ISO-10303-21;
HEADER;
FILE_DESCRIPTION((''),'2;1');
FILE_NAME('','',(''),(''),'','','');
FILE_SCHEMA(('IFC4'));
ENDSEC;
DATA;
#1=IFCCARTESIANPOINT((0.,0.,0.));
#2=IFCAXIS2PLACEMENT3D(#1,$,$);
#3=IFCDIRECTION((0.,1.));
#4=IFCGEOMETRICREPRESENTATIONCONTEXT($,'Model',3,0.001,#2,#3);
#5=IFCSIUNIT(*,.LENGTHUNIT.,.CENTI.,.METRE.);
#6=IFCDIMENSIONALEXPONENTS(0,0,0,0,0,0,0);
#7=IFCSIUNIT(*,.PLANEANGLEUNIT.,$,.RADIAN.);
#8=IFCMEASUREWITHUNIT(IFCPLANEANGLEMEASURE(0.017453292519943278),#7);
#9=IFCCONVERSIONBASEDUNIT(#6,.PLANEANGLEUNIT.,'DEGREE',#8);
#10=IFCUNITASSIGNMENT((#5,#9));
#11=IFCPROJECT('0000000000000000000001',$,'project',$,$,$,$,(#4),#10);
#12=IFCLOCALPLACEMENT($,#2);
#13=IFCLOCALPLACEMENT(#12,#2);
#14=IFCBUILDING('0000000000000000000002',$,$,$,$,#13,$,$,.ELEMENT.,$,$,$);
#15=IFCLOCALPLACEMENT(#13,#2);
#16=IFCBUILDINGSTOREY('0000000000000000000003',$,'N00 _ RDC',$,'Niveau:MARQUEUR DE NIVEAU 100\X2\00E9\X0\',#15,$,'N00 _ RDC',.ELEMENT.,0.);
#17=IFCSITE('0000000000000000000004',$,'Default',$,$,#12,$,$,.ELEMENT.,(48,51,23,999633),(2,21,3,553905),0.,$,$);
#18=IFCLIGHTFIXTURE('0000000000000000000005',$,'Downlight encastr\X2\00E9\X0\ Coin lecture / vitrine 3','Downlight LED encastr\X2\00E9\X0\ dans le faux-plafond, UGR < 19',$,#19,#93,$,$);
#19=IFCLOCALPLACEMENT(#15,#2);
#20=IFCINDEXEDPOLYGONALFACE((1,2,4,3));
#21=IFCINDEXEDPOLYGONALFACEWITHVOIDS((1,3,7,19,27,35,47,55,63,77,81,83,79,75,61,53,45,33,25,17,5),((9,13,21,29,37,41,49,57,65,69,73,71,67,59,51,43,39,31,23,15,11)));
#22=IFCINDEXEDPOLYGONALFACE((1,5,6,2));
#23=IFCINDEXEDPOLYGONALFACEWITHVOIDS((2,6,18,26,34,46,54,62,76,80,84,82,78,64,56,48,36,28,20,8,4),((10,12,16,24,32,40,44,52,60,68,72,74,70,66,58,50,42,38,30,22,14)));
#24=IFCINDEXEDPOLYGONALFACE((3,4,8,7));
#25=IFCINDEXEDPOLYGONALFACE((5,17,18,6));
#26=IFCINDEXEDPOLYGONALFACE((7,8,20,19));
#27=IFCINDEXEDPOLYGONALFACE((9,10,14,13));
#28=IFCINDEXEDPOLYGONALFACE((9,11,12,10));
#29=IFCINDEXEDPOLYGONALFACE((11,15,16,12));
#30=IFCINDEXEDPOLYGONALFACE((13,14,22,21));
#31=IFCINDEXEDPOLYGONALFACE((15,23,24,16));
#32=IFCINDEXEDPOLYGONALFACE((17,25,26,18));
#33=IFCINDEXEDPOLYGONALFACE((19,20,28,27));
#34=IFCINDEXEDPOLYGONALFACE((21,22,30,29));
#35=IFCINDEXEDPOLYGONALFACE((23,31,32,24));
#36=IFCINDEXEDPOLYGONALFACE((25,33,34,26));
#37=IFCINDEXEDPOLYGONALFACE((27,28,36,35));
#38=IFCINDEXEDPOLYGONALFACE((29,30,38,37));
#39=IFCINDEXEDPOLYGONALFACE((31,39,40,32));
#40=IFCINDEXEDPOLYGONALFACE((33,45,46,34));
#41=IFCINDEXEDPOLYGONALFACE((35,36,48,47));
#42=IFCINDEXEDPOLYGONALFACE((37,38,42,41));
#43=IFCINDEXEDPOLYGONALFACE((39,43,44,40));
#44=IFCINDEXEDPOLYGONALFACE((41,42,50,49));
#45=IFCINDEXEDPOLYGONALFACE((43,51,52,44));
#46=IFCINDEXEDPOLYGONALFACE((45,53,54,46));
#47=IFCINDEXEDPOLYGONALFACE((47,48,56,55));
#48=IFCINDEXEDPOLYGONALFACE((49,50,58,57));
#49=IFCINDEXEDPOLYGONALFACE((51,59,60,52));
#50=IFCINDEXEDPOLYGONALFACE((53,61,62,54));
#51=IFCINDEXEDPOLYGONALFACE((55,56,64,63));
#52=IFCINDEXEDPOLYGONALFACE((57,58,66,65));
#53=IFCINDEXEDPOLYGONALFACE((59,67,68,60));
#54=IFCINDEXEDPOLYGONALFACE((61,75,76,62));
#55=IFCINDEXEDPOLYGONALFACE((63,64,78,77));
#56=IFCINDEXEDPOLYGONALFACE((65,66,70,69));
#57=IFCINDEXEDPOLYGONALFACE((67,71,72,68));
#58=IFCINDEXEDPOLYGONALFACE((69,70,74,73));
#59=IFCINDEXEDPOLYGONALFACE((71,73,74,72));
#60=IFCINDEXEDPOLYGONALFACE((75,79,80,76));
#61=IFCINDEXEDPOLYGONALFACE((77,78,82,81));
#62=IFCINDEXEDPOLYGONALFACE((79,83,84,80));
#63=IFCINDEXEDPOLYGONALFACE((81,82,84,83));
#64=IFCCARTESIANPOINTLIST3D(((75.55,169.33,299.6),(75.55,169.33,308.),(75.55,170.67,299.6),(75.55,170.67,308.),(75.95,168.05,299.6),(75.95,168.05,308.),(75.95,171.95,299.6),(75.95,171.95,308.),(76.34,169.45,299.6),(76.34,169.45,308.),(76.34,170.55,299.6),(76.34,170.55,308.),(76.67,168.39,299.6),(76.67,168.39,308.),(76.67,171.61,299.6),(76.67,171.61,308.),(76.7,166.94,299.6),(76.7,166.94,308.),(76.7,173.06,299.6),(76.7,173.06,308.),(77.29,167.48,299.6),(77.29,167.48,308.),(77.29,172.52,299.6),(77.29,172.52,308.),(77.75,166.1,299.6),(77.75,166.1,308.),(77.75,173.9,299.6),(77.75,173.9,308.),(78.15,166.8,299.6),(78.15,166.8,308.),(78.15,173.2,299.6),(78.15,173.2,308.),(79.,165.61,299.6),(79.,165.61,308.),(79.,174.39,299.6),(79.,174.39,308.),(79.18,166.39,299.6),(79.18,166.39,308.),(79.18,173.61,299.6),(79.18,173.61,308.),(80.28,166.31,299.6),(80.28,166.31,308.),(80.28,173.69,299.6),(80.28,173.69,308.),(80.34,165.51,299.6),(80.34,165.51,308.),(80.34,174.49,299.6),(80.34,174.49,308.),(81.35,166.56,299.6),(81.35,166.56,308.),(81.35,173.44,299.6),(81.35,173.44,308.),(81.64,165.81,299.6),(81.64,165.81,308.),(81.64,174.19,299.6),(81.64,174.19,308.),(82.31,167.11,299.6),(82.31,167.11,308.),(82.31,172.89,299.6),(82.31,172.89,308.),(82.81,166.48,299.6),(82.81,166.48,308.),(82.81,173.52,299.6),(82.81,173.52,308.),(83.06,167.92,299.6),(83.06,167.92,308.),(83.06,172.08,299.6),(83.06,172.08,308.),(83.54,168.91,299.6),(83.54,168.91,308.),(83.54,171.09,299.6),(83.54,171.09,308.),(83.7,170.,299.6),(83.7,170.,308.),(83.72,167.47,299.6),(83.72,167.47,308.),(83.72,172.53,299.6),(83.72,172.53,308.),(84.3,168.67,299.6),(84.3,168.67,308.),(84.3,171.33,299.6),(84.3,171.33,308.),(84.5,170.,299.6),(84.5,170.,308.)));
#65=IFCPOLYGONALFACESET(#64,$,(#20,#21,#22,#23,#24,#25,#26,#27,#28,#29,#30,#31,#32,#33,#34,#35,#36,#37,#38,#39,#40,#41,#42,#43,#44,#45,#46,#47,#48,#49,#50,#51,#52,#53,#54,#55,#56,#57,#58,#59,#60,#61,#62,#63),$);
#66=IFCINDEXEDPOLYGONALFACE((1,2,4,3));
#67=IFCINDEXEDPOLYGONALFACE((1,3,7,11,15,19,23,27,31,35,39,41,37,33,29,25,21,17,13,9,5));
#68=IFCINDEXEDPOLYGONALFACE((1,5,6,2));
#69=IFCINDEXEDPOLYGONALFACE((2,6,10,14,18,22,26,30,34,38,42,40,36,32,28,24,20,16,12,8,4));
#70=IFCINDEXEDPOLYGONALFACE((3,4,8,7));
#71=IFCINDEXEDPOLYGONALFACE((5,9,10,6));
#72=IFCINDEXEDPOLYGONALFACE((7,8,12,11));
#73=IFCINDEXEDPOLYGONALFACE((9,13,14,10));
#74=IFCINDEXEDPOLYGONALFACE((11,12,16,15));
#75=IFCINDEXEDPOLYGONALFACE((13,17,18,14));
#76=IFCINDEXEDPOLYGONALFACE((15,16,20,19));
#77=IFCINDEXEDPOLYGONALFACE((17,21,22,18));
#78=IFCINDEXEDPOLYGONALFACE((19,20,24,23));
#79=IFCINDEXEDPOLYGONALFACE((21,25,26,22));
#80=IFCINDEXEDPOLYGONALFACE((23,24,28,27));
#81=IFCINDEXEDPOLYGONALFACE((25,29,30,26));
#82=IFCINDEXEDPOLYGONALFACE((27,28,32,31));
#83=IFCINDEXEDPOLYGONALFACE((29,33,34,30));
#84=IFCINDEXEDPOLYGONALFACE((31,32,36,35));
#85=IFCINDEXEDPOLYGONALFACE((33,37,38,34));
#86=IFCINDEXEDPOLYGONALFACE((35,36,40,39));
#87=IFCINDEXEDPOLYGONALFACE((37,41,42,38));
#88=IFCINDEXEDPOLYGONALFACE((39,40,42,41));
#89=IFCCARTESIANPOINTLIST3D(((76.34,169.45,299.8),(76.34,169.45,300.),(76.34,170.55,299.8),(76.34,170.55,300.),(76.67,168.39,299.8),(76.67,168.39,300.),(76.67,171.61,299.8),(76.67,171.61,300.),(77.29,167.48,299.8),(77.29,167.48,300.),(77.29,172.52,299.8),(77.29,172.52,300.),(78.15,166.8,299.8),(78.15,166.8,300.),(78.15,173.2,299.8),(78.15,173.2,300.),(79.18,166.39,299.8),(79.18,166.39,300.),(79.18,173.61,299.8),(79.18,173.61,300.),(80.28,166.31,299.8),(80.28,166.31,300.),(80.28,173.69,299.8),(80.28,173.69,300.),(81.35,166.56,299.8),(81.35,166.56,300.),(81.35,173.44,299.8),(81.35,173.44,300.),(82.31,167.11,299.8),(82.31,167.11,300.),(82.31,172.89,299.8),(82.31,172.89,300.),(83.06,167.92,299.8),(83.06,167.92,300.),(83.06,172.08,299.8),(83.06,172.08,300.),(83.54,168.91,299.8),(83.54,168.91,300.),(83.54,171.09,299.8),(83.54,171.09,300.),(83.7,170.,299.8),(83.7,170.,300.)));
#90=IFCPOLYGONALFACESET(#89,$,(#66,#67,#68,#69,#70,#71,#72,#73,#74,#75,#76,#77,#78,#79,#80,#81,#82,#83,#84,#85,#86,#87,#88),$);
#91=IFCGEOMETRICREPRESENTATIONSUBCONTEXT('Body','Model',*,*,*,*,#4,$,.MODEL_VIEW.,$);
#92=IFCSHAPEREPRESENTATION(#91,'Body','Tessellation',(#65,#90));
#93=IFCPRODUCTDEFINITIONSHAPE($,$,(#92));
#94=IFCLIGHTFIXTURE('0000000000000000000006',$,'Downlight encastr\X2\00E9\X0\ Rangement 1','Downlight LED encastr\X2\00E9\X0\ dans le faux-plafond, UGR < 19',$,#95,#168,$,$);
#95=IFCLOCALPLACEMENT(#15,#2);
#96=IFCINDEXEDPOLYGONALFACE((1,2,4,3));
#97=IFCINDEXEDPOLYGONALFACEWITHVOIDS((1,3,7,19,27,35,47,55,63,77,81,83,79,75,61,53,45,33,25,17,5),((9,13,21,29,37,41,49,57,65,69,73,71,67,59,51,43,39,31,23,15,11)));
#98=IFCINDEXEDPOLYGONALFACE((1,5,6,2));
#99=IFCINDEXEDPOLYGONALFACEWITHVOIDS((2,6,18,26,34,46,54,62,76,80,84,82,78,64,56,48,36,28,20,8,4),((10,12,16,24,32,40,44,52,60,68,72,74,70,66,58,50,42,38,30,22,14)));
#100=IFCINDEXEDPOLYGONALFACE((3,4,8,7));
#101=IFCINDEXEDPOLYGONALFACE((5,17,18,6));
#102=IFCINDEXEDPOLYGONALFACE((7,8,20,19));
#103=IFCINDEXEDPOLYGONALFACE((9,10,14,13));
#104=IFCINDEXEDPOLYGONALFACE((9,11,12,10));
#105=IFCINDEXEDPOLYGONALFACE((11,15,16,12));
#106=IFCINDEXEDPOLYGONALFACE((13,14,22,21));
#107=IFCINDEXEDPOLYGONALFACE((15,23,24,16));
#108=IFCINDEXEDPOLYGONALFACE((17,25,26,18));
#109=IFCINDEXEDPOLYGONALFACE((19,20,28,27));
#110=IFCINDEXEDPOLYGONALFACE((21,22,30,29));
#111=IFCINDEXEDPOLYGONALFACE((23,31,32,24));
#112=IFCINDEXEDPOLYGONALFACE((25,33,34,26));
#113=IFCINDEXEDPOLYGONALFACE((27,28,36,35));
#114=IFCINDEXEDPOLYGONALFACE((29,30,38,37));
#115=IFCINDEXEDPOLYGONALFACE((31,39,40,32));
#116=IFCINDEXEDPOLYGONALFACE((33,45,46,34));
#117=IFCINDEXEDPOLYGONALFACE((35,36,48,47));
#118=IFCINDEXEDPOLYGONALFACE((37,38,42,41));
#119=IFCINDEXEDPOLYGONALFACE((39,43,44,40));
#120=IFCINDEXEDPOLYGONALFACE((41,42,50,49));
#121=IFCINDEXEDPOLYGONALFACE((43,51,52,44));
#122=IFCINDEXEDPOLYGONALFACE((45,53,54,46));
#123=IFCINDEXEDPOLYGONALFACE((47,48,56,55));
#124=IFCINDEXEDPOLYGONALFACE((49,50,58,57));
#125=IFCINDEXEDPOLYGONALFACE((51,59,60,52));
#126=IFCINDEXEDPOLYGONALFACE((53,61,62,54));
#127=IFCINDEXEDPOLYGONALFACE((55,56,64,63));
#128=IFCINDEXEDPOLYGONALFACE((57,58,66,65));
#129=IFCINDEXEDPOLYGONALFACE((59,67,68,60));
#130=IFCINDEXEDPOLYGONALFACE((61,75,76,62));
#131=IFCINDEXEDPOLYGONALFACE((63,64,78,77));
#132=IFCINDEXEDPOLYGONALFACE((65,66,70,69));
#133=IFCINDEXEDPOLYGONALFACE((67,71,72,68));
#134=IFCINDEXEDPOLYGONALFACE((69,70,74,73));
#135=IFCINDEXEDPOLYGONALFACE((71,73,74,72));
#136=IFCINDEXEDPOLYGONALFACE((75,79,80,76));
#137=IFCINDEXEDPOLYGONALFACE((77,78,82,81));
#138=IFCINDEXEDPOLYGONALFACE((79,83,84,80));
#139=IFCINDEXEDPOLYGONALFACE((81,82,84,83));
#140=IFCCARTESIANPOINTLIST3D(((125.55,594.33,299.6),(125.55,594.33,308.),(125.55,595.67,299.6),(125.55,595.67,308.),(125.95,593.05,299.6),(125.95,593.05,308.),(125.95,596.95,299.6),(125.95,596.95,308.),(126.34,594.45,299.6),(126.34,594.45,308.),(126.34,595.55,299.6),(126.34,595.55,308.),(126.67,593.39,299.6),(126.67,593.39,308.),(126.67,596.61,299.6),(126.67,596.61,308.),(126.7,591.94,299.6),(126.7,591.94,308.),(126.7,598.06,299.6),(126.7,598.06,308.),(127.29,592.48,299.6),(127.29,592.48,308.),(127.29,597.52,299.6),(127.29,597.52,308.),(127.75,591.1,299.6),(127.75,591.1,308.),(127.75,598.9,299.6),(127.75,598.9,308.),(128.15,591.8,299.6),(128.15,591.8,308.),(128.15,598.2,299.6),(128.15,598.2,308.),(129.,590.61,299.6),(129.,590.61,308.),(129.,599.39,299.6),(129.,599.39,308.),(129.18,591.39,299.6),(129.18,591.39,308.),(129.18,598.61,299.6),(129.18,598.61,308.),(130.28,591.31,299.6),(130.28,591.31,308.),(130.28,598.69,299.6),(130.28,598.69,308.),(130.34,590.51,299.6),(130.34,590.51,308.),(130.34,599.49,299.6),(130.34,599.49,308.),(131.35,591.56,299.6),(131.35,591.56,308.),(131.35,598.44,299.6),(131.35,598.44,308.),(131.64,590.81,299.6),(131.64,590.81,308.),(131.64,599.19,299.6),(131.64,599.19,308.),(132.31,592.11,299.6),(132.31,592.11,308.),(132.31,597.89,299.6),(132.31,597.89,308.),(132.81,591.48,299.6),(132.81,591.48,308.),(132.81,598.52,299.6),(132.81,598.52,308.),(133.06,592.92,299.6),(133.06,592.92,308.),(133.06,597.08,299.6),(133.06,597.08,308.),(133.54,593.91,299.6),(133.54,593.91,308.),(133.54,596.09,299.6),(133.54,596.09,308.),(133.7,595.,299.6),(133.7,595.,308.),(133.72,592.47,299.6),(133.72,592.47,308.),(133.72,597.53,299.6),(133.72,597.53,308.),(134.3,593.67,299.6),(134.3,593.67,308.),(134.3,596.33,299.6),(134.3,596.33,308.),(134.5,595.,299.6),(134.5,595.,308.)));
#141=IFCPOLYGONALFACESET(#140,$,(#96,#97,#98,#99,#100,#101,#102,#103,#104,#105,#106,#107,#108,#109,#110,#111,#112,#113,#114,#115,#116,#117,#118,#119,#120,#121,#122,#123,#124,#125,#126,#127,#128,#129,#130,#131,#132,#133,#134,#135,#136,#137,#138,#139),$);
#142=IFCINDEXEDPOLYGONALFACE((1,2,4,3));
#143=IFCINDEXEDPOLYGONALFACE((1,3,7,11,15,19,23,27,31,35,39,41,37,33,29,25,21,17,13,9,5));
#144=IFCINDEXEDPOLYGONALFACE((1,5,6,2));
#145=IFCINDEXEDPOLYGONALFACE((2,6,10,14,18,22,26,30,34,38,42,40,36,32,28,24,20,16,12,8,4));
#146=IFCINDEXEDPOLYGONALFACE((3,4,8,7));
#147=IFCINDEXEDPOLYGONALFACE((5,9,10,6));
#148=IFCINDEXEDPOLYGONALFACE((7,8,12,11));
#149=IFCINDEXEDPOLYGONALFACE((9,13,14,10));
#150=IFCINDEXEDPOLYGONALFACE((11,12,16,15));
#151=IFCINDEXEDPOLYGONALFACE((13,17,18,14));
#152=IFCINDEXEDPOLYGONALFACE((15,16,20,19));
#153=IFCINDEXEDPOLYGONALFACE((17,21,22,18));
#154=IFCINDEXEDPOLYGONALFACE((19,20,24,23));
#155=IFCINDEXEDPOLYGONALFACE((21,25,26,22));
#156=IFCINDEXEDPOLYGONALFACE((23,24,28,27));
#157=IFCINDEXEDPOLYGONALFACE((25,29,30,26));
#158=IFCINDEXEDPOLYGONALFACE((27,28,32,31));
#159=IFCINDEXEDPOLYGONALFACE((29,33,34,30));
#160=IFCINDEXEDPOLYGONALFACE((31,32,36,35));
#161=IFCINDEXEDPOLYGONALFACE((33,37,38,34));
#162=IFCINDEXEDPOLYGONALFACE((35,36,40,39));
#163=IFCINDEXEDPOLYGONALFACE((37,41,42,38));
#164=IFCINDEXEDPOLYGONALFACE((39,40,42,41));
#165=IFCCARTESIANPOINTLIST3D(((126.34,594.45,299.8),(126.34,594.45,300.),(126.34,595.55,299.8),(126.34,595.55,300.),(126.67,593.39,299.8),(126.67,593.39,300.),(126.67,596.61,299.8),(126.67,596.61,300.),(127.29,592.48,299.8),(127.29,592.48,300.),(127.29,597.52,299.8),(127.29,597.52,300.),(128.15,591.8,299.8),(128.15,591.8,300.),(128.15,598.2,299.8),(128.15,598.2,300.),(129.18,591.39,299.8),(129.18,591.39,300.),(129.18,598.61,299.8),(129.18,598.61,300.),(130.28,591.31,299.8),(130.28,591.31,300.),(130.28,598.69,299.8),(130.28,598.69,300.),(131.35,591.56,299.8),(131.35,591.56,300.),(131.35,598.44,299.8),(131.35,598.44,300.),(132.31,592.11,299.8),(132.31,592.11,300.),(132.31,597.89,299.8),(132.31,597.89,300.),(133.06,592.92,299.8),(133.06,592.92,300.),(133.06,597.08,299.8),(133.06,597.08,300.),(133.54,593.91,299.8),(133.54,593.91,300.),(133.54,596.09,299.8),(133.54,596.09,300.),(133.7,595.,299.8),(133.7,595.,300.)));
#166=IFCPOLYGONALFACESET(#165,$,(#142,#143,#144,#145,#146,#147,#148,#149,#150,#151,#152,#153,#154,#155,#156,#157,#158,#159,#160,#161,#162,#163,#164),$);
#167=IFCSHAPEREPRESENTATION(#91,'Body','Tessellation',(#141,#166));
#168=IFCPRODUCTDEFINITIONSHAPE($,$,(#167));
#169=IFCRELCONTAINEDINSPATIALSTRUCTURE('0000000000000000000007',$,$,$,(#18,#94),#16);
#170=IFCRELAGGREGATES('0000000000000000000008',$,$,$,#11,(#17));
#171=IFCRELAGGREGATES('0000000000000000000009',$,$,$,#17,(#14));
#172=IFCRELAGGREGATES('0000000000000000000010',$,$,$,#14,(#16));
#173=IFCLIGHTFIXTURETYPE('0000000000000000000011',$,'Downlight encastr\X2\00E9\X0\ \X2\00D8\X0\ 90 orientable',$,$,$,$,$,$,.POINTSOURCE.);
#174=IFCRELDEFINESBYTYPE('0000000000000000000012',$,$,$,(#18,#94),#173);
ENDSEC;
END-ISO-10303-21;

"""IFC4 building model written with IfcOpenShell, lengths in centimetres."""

from ifc_helpers import new_model, entity, si_unit, converted_unit, direction, frame, frame_2d, origin, origin_with_axes, place, context, subcontext, project, spatial, circle, hollow_circle, extrude, type_object, element, save


model = new_model("IFC4")

# Units and contexts
model_context = context("Model", 3, precision=0.001, world=origin(), true_north=direction((0.0, 1.0)))
body_context = subcontext(model_context, "Body", "Model", "MODEL_VIEW")
ifc_project = project(units=[si_unit("LENGTHUNIT", "METRE", prefix="CENTI"), converted_unit("PLANEANGLEUNIT", "DEGREE", entity("IfcPlaneAngleMeasure", 0.017453292519943278), si_unit("PLANEANGLEUNIT", "RADIAN"), dimensions=[0, 0, 0, 0, 0, 0, 0])], contexts=[model_context])

# Site, building, storey
site_placement = place(None, origin())
site = spatial("IfcSite", under=ifc_project, at=site_placement, Name="Default", CompositionType="ELEMENT", RefLatitude=(48, 51, 23, 999633), RefLongitude=(2, 21, 3, 553905), RefElevation=0.0)
building_placement = place(site_placement, origin())
building = spatial("IfcBuilding", under=site, at=building_placement, CompositionType="ELEMENT")
storey_placement = place(building_placement, origin())
storey = spatial("IfcBuildingStorey", under=building, at=storey_placement, Name="N00 _ RDC", ObjectType="Niveau:MARQUEUR DE NIVEAU 100é", LongName="N00 _ RDC", CompositionType="ELEMENT", Elevation=0.0)

# Light fixtures
light_fixture_type_1 = type_object("IfcLightFixtureType", Name="Downlight encastré Ø 90 orientable", PredefinedType="POINTSOURCE")
light_fixture_1_placement = place(storey_placement, origin_with_axes())
element("IfcLightFixture", 1, at=light_fixture_1_placement, inside=storey, type_object=light_fixture_type_1, Name="Downlight encastré Coin lecture / vitrine 3", Description="Downlight LED encastré dans le faux-plafond, UGR < 19", context=body_context, shape_type="SweptSolid", body=[
    extrude(hollow_circle(Radius=4.5, WallThickness=0.8, at=frame_2d((80.0, 170.0))), frame((0.0, 0.0, 299.6)), (0.0, 0.0, 1.0), 8.4),
    extrude(circle(Radius=3.7, at=frame_2d((80.0, 170.0))), frame((0.0, 0.0, 299.8)), (0.0, 0.0, 1.0), 0.2),
])
light_fixture_2_placement = place(storey_placement, origin_with_axes())
element("IfcLightFixture", 2, at=light_fixture_2_placement, inside=storey, type_object=light_fixture_type_1, Name="Downlight encastré Rangement 1", Description="Downlight LED encastré dans le faux-plafond, UGR < 19", context=body_context, shape_type="SweptSolid", body=[
    extrude(hollow_circle(Radius=4.5, WallThickness=0.8, at=frame_2d((130.0, 595.0))), frame((0.0, 0.0, 299.6)), (0.0, 0.0, 1.0), 8.4),
    extrude(circle(Radius=3.7, at=frame_2d((130.0, 595.0))), frame((0.0, 0.0, 299.8)), (0.0, 0.0, 1.0), 0.2),
])

save(model, "model.ifc")
